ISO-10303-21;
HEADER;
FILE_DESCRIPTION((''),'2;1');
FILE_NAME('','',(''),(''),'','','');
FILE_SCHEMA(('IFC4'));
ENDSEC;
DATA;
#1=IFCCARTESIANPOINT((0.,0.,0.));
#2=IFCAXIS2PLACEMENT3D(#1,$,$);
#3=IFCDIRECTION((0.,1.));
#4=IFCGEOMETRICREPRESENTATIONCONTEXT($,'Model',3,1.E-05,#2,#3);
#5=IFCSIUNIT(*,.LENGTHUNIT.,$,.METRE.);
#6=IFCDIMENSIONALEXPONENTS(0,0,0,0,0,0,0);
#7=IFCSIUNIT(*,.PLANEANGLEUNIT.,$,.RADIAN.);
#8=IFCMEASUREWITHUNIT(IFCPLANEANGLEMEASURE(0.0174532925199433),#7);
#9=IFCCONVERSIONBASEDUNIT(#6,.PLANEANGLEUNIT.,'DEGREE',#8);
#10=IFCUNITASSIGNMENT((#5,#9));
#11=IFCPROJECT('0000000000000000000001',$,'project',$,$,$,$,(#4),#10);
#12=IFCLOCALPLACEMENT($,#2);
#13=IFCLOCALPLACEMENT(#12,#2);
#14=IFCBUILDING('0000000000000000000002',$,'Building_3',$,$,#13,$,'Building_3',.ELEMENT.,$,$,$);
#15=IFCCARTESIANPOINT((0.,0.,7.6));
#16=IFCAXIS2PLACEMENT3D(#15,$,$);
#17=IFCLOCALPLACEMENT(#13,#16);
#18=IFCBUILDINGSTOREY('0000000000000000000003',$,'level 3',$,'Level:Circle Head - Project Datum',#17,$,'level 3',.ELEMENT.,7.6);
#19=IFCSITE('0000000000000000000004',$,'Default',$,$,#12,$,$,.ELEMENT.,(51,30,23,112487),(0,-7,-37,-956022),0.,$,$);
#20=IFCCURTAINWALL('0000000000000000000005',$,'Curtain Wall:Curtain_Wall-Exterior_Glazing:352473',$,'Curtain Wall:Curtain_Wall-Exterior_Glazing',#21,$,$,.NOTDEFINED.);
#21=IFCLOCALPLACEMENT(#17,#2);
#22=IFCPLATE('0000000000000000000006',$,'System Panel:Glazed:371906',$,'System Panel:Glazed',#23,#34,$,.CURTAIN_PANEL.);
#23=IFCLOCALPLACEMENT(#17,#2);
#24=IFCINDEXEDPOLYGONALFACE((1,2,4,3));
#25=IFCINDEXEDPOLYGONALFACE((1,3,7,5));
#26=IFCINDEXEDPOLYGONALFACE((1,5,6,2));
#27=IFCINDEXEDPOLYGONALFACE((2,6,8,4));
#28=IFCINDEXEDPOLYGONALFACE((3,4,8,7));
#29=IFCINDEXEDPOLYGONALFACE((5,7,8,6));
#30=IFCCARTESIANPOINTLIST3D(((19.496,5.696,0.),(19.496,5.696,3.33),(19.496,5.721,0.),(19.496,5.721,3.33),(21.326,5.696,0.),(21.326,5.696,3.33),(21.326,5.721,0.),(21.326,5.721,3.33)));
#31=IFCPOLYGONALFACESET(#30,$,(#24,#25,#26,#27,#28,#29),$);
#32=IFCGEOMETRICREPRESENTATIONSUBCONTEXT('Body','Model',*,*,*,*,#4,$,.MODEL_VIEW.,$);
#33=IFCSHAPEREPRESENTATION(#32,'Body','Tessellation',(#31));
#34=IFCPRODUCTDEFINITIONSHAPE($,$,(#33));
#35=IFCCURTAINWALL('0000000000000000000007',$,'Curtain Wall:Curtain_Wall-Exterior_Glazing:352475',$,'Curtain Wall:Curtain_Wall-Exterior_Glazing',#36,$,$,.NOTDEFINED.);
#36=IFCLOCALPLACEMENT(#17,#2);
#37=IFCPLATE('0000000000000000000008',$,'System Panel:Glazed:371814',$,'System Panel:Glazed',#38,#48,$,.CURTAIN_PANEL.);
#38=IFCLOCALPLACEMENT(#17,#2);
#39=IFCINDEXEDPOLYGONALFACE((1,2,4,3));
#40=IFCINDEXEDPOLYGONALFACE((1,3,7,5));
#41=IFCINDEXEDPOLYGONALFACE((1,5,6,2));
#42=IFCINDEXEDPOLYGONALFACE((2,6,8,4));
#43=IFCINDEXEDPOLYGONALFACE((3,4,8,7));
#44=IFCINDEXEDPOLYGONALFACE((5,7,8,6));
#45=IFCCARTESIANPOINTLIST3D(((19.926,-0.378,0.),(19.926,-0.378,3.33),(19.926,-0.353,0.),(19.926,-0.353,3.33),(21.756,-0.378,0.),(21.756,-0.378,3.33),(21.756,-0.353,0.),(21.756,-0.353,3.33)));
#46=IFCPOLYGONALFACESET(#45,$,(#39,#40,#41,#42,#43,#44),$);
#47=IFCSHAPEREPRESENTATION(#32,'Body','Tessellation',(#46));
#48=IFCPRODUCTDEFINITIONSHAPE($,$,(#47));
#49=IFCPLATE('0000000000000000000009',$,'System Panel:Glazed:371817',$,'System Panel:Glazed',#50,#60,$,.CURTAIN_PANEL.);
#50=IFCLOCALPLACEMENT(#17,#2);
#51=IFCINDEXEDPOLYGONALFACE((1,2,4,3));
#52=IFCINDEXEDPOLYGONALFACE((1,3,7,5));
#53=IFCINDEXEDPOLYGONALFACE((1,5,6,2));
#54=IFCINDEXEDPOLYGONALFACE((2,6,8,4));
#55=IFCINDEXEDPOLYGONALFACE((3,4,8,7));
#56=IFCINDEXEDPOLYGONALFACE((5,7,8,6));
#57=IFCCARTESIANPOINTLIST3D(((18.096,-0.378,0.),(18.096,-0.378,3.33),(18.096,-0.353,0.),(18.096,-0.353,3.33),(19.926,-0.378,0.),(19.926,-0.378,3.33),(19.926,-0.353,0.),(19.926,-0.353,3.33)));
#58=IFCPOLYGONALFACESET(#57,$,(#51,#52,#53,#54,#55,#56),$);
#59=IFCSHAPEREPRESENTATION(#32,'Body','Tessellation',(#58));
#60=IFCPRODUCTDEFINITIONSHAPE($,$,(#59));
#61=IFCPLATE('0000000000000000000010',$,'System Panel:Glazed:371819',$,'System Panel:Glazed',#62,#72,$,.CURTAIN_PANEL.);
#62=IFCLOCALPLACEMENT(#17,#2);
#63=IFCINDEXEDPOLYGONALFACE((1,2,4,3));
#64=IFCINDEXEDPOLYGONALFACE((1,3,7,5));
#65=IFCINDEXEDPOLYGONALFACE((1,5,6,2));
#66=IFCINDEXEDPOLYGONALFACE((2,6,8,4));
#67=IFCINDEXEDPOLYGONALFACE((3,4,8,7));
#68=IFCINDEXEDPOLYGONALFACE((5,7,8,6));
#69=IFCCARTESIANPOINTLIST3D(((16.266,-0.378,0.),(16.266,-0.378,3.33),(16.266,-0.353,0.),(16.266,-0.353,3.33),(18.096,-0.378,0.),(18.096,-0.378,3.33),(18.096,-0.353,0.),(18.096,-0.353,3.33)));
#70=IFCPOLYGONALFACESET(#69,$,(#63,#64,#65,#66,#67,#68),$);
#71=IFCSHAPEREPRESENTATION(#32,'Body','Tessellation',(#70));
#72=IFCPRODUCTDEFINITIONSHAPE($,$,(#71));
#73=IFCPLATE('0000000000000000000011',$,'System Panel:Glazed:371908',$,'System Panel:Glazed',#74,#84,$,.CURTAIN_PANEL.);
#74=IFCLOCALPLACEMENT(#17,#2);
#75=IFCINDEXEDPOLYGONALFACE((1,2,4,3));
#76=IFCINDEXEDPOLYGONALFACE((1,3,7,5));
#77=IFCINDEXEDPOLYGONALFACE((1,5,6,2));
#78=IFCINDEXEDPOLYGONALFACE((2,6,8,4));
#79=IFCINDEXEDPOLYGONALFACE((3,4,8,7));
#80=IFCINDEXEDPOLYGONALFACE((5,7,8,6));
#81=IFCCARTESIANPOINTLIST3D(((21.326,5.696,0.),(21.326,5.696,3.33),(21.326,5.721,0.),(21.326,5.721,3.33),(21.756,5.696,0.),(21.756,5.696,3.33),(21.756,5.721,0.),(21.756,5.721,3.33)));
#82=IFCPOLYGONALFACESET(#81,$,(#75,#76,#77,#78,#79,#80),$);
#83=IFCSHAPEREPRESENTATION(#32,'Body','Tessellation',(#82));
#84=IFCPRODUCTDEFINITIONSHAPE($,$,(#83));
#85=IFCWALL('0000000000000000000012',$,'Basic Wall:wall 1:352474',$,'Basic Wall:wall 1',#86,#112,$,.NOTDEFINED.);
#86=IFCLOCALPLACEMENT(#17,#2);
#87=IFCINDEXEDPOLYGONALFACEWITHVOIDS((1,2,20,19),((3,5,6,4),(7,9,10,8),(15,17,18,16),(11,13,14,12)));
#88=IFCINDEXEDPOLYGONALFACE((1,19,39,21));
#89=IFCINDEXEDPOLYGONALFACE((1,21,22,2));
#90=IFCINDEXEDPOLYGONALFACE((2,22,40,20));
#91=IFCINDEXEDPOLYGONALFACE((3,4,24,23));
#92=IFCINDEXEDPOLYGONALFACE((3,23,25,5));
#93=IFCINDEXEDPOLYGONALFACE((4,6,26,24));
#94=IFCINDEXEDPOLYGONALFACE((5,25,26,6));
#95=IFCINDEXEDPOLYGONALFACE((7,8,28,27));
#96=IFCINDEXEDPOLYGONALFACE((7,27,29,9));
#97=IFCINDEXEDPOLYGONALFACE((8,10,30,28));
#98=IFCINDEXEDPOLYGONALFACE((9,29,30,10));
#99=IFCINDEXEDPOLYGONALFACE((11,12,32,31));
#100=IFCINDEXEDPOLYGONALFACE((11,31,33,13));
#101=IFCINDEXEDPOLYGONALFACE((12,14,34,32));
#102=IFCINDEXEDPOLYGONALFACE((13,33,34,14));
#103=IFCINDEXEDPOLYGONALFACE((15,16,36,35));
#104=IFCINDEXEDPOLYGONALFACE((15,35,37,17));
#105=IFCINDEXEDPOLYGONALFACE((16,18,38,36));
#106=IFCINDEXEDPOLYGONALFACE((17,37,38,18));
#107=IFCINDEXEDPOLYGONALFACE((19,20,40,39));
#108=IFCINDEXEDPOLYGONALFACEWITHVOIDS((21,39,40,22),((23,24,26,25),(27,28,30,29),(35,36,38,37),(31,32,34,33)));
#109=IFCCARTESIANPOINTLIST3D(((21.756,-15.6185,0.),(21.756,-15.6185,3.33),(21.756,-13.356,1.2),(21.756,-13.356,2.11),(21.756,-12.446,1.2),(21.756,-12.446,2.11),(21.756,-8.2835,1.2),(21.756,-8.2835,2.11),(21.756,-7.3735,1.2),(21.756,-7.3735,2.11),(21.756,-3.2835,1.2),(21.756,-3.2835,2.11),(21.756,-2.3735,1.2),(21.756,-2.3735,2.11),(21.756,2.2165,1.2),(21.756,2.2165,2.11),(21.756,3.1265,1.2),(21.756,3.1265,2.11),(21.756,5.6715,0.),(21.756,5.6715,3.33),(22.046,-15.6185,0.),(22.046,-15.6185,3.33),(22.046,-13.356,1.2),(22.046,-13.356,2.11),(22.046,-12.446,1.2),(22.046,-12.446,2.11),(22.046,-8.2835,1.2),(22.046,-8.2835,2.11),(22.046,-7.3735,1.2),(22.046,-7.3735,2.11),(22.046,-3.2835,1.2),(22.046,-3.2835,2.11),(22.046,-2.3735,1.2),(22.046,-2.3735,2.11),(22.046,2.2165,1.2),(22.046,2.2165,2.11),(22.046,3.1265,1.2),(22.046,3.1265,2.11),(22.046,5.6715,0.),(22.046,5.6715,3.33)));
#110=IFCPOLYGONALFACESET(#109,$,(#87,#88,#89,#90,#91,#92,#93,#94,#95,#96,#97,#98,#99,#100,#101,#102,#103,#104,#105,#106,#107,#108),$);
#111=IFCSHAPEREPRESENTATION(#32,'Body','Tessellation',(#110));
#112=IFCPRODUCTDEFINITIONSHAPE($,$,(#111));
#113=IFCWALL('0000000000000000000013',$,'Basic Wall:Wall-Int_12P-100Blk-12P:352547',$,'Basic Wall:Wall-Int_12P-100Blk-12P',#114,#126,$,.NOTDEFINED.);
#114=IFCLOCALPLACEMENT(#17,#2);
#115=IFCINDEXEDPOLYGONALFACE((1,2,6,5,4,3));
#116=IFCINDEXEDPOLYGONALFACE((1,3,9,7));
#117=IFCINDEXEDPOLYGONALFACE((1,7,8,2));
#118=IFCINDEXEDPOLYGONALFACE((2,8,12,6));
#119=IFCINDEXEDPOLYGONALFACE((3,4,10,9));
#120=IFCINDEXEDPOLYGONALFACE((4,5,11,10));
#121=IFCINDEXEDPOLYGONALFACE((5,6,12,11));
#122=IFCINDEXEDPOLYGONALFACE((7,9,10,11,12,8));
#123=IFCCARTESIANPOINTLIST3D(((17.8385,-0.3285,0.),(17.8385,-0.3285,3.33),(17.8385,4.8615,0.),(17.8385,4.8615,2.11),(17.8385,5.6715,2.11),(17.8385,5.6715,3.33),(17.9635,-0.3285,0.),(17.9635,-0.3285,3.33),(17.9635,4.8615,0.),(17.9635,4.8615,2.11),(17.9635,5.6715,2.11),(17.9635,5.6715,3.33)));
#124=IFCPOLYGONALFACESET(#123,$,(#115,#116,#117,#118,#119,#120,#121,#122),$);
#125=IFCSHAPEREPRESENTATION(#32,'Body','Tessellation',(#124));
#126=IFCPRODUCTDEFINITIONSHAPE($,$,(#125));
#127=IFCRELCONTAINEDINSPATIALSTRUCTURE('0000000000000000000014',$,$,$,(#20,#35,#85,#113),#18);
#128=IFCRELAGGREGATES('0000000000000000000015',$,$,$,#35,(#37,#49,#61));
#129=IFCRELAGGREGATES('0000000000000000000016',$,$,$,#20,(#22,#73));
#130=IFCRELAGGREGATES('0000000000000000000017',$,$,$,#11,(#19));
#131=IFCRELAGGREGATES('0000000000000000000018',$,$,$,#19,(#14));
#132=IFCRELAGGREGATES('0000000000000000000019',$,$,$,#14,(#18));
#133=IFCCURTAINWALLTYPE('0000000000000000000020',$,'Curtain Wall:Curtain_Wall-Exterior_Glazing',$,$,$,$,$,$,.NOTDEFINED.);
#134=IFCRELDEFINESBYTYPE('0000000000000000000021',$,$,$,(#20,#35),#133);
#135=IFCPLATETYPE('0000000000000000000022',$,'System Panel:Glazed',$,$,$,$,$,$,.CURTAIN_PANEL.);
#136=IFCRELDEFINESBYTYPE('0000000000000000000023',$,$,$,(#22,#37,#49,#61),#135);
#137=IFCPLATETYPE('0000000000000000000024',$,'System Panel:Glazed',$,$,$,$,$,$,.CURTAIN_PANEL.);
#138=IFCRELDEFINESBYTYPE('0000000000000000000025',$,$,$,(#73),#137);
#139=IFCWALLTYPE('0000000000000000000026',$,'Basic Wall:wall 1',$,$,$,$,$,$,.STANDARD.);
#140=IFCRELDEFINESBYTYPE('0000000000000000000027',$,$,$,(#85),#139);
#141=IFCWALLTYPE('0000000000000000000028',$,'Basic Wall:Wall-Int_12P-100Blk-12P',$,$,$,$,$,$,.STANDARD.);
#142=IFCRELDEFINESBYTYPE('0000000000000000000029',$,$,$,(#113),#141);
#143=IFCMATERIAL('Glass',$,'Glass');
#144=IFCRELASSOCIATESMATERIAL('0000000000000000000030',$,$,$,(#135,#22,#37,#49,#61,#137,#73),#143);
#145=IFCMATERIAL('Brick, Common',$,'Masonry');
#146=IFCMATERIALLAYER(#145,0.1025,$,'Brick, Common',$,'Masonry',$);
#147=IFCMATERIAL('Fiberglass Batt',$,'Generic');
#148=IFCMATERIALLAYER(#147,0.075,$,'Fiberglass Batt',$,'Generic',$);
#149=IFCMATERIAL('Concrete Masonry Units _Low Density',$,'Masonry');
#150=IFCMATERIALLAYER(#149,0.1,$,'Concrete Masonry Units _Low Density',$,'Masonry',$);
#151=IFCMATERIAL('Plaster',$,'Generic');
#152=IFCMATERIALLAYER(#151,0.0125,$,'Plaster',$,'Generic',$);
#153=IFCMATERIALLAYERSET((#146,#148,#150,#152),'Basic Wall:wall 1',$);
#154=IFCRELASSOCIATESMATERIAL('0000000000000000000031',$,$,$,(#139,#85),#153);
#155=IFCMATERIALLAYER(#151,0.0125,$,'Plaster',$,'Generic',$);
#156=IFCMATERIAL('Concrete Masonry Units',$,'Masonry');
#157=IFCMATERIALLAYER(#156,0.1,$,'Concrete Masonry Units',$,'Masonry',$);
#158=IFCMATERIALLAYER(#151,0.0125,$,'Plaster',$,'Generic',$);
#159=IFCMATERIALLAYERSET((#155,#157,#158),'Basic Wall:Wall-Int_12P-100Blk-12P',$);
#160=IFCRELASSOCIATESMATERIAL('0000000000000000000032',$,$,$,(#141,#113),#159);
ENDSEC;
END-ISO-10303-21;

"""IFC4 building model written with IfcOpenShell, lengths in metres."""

from ifc_helpers import new_model, entity, si_unit, converted_unit, direction, frame, frame_2d, origin, origin_2d_with_axis, place, context, subcontext, project, spatial, polyline, rectangle, extrude, clip, bounded_halfspace, source, transform, mapped, material, layer, layer_set, layer_usage, type_object, type_shapes, element, aggregate, save


model = new_model("IFC4")

# Units and contexts
model_context = context("Model", 3, precision=1e-05, world=origin(), true_north=direction((0.0, 1.0)))
body_context = subcontext(model_context, "Body", "Model", "MODEL_VIEW")
ifc_project = project(units=[si_unit("LENGTHUNIT", "METRE"), converted_unit("PLANEANGLEUNIT", "DEGREE", entity("IfcPlaneAngleMeasure", 0.0174532925199433), si_unit("PLANEANGLEUNIT", "RADIAN"), dimensions=[0, 0, 0, 0, 0, 0, 0])], contexts=[model_context])

# Site, building, storey
site_placement = place(None, origin())
site = spatial("IfcSite", under=ifc_project, at=site_placement, Name="Default", CompositionType="ELEMENT", RefLatitude=(51, 30, 23, 112487), RefLongitude=(0, -7, -37, -956022), RefElevation=0.0)
building_placement = place(site_placement, origin())
building = spatial("IfcBuilding", under=site, at=building_placement, Name="Building_3", LongName="Building_3", CompositionType="ELEMENT")
storey_placement = place(building_placement, frame((0.0, 0.0, 7.6)))
storey = spatial("IfcBuildingStorey", under=building, at=storey_placement, Name="level 3", ObjectType="Level:Circle Head - Project Datum", LongName="level 3", CompositionType="ELEMENT", Elevation=7.6)

# Curtain wall, plate
curtain_wall_type = type_object("IfcCurtainWallType", Name="Curtain Wall:Curtain_Wall-Exterior_Glazing", PredefinedType="NOTDEFINED")
curtain_wall_1_placement = place(storey_placement, frame((0.0, 0.0, -7.6)))
curtain_wall_1 = element("IfcCurtainWall", 1, at=curtain_wall_1_placement, inside=storey, type_object=curtain_wall_type, Name="Curtain Wall:Curtain_Wall-Exterior_Glazing:352473", ObjectType="Curtain Wall:Curtain_Wall-Exterior_Glazing", PredefinedType="NOTDEFINED")
ifc_material_1 = material(Name="Glass", Category="Glass")
plate_type_1 = type_object("IfcPlateType", Name="System Panel:Glazed", PredefinedType="CURTAIN_PANEL", material=ifc_material_1)
shared_shape_1 = source(origin(), body_context, "Body", "SweptSolid", [
    extrude(rectangle(XDim=0.025, YDim=1.83, at=origin_2d_with_axis()), frame((0.915, 0.0125, 0.0), z_axis=(0.0, 0.0, 1.0), x_axis=(0.0, 1.0, 0.0)), (0.0, 0.0, 1.0), 3.33),
])
type_shapes(plate_type_1, [shared_shape_1])
plate_1_placement = place(curtain_wall_1_placement, frame((19.496, 5.696, 7.6)))
plate_1 = element("IfcPlate", 2, at=plate_1_placement, type_object=plate_type_1, material=ifc_material_1, Name="System Panel:Glazed:371906", ObjectType="System Panel:Glazed", PredefinedType="CURTAIN_PANEL", context=body_context, shape_type="MappedRepresentation", body=[
    mapped(shared_shape_1, transform((0.0, 0.0, 0.0), scale=1.0)),
])

# Curtain wall, plates
curtain_wall_2_placement = place(storey_placement, frame((0.0, 0.0, -7.6)))
curtain_wall_2 = element("IfcCurtainWall", 3, at=curtain_wall_2_placement, inside=storey, type_object=curtain_wall_type, Name="Curtain Wall:Curtain_Wall-Exterior_Glazing:352475", ObjectType="Curtain Wall:Curtain_Wall-Exterior_Glazing", PredefinedType="NOTDEFINED")
plate_2_placement = place(curtain_wall_2_placement, frame((21.756, -0.353, 7.6), z_axis=(0.0, 0.0, 1.0), x_axis=(-1.0, 0.0, 0.0)))
plate_2 = element("IfcPlate", 4, at=plate_2_placement, type_object=plate_type_1, material=ifc_material_1, Name="System Panel:Glazed:371814", ObjectType="System Panel:Glazed", PredefinedType="CURTAIN_PANEL", context=body_context, shape_type="MappedRepresentation", body=[
    mapped(shared_shape_1, transform((0.0, 0.0, 0.0), scale=1.0)),
])
plate_3_placement = place(curtain_wall_2_placement, frame((19.926, -0.353, 7.6), z_axis=(0.0, 0.0, 1.0), x_axis=(-1.0, 0.0, 0.0)))
plate_3 = element("IfcPlate", 5, at=plate_3_placement, type_object=plate_type_1, material=ifc_material_1, Name="System Panel:Glazed:371817", ObjectType="System Panel:Glazed", PredefinedType="CURTAIN_PANEL", context=body_context, shape_type="MappedRepresentation", body=[
    mapped(shared_shape_1, transform((0.0, 0.0, 0.0), scale=1.0)),
])
plate_4_placement = place(curtain_wall_2_placement, frame((18.096, -0.353, 7.6), z_axis=(0.0, 0.0, 1.0), x_axis=(-1.0, 0.0, 0.0)))
plate_4 = element("IfcPlate", 6, at=plate_4_placement, type_object=plate_type_1, material=ifc_material_1, Name="System Panel:Glazed:371819", ObjectType="System Panel:Glazed", PredefinedType="CURTAIN_PANEL", context=body_context, shape_type="MappedRepresentation", body=[
    mapped(shared_shape_1, transform((0.0, 0.0, 0.0), scale=1.0)),
])
aggregate(curtain_wall_2, [plate_2, plate_3, plate_4])

# Plate
plate_type_2 = type_object("IfcPlateType", Name="System Panel:Glazed", PredefinedType="CURTAIN_PANEL", material=ifc_material_1)
shared_shape_2 = source(origin(), body_context, "Body", "SweptSolid", [
    extrude(rectangle(XDim=0.025, YDim=0.43, at=origin_2d_with_axis()), frame((0.215, 0.0125, 0.0), z_axis=(0.0, 0.0, 1.0), x_axis=(0.0, 1.0, 0.0)), (0.0, 0.0, 1.0), 3.33),
])
type_shapes(plate_type_2, [shared_shape_2])
plate_5_placement = place(curtain_wall_1_placement, frame((21.326, 5.696, 7.6)))
plate_5 = element("IfcPlate", 7, at=plate_5_placement, type_object=plate_type_2, material=ifc_material_1, Name="System Panel:Glazed:371908", ObjectType="System Panel:Glazed", PredefinedType="CURTAIN_PANEL", context=body_context, shape_type="MappedRepresentation", body=[
    mapped(shared_shape_2, transform((0.0, 0.0, 0.0), scale=1.0)),
])
aggregate(curtain_wall_1, [plate_1, plate_5])

# Wall, openings
ifc_material_2 = material(Name="Brick, Common", Category="Masonry")
ifc_layer_1 = layer(ifc_material_2, 0.1025, Name="Brick, Common", Category="Masonry")
ifc_material_3 = material(Name="Fiberglass Batt", Category="Generic")
ifc_layer_2 = layer(ifc_material_3, 0.075, Name="Fiberglass Batt", Category="Generic")
ifc_material_4 = material(Name="Concrete Masonry Units _Low Density", Category="Masonry")
ifc_layer_3 = layer(ifc_material_4, 0.1, Name="Concrete Masonry Units _Low Density", Category="Masonry")
ifc_material_5 = material(Name="Plaster", Category="Generic")
ifc_layer_4 = layer(ifc_material_5, 0.0125, Name="Plaster", Category="Generic")
ifc_layer_set_1 = layer_set([ifc_layer_1, ifc_layer_2, ifc_layer_3, ifc_layer_4], Name="Basic Wall:wall 1")
ifc_layer_usage_1 = layer_usage(ifc_layer_set_1, "AXIS2", "NEGATIVE", 0.145)
wall_type_1 = type_object("IfcWallType", Name="Basic Wall:wall 1", PredefinedType="STANDARD", material=ifc_layer_set_1)
wall_1_placement = place(storey_placement, frame((21.901, 5.6715, 0.0), z_axis=(0.0, 0.0, 1.0), x_axis=(0.0, -1.0, 0.0)))
wall_1 = element("IfcWall", 8, at=wall_1_placement, inside=storey, type_object=wall_type_1, material=ifc_layer_usage_1, Name="Basic Wall:wall 1:352474", ObjectType="Basic Wall:wall 1", PredefinedType="NOTDEFINED", context=body_context, shape_type="Clipping", body=[
    clip(extrude(rectangle(XDim=21.29, YDim=0.29, at=frame_2d((10.645, 0.0), x_axis=(-1.0, 0.0))), origin(), (0.0, 0.0, 1.0), 3.33), bounded_halfspace(frame((0.0, -0.145, 3.33), z_axis=(0.0, 0.0, -1.0), x_axis=(-1.0, 0.0, 0.0)), True, frame((0.0, -0.145, 3.33)), polyline([(0.0, 0.0), (10.9375, 0.0), (11.0625, 0.0), (15.9375, 0.0), (16.0625, 0.0), (21.0, 0.0), (21.29, 0.0), (21.29, 0.29), (0.0, 0.29), (0.0, 0.0)]))),
])
opening_1_placement = place(wall_1_placement, frame((5.6715, -21.901, 0.0)))
element("IfcOpeningElement", 9, at=opening_1_placement, cuts=wall_1, PredefinedType="OPENING", context=body_context, shape_type="SweptSolid", body=[
    extrude(rectangle(XDim=2.11, YDim=0.125, at=frame_2d((0.0, 0.0), x_axis=(0.0, 1.0))), frame((5.3285, 20.946, 1.055), z_axis=(0.0, 1.0, 0.0), x_axis=(1.0, 0.0, 0.0)), (0.0, 0.0, 1.0), 0.81),
])
opening_2_placement = place(wall_1_placement, frame((5.6715, -21.901, 0.0)))
element("IfcOpeningElement", 10, at=opening_2_placement, cuts=wall_1, PredefinedType="OPENING", context=body_context, shape_type="SweptSolid", body=[
    extrude(rectangle(XDim=2.11, YDim=0.125, at=frame_2d((0.0, 0.0), x_axis=(0.0, 1.0))), frame((10.3285, 20.946, 1.055), z_axis=(0.0, 1.0, 0.0), x_axis=(1.0, 0.0, 0.0)), (0.0, 0.0, 1.0), 0.81),
])
opening_3_placement = place(wall_1_placement, frame((2.545, -0.145, 1.2)))
element("IfcOpeningElement", 11, at=opening_3_placement, cuts=wall_1, PredefinedType="OPENING", context=body_context, shape_type="SweptSolid", body=[
    extrude(rectangle(XDim=0.91, YDim=0.91, at=frame_2d((0.455, 0.455), x_axis=(-1.0, 0.0))), frame((0.0, 0.0, 0.0), z_axis=(0.0, 1.0, 0.0), x_axis=(0.0, 0.0, 1.0)), (0.0, 0.0, 1.0), 0.29),
])
opening_4_placement = place(wall_1_placement, frame((8.045, -0.145, 1.2)))
element("IfcOpeningElement", 12, at=opening_4_placement, cuts=wall_1, PredefinedType="OPENING", context=body_context, shape_type="SweptSolid", body=[
    extrude(rectangle(XDim=0.91, YDim=0.91, at=frame_2d((0.455, 0.455), x_axis=(-1.0, 0.0))), frame((0.0, 0.0, 0.0), z_axis=(0.0, 1.0, 0.0), x_axis=(0.0, 0.0, 1.0)), (0.0, 0.0, 1.0), 0.29),
])
opening_5_placement = place(wall_1_placement, frame((18.1175, -0.145, 1.2)))
element("IfcOpeningElement", 13, at=opening_5_placement, cuts=wall_1, PredefinedType="OPENING", context=body_context, shape_type="SweptSolid", body=[
    extrude(rectangle(XDim=0.91, YDim=0.91, at=frame_2d((0.455, 0.455), x_axis=(-1.0, 0.0))), frame((0.0, 0.0, 0.0), z_axis=(0.0, 1.0, 0.0), x_axis=(0.0, 0.0, 1.0)), (0.0, 0.0, 1.0), 0.29),
])
opening_6_placement = place(wall_1_placement, frame((13.045, -0.145, 1.2)))
element("IfcOpeningElement", 14, at=opening_6_placement, cuts=wall_1, PredefinedType="OPENING", context=body_context, shape_type="SweptSolid", body=[
    extrude(rectangle(XDim=0.91, YDim=0.91, at=frame_2d((0.455, 0.455), x_axis=(-1.0, 0.0))), frame((0.0, 0.0, 0.0), z_axis=(0.0, 1.0, 0.0), x_axis=(0.0, 0.0, 1.0)), (0.0, 0.0, 1.0), 0.29),
])

# Wall, opening
ifc_layer_5 = layer(ifc_material_5, 0.0125, Name="Plaster", Category="Generic")
ifc_material_6 = material(Name="Concrete Masonry Units", Category="Masonry")
ifc_layer_6 = layer(ifc_material_6, 0.1, Name="Concrete Masonry Units", Category="Masonry")
ifc_layer_7 = layer(ifc_material_5, 0.0125, Name="Plaster", Category="Generic")
ifc_layer_set_2 = layer_set([ifc_layer_5, ifc_layer_6, ifc_layer_7], Name="Basic Wall:Wall-Int_12P-100Blk-12P")
ifc_layer_usage_2 = layer_usage(ifc_layer_set_2, "AXIS2", "NEGATIVE", 0.0625)
wall_type_2 = type_object("IfcWallType", Name="Basic Wall:Wall-Int_12P-100Blk-12P", PredefinedType="STANDARD", material=ifc_layer_set_2)
wall_2_placement = place(storey_placement, frame((17.901, 5.6715, 0.0), z_axis=(0.0, 0.0, 1.0), x_axis=(0.0, -1.0, 0.0)))
wall_2 = element("IfcWall", 15, at=wall_2_placement, inside=storey, type_object=wall_type_2, material=ifc_layer_usage_2, Name="Basic Wall:Wall-Int_12P-100Blk-12P:352547", ObjectType="Basic Wall:Wall-Int_12P-100Blk-12P", PredefinedType="NOTDEFINED", context=body_context, shape_type="Clipping", body=[
    clip(extrude(rectangle(XDim=6.0, YDim=0.125, at=frame_2d((3.0, 0.0), x_axis=(-1.0, 0.0))), origin(), (0.0, 0.0, 1.0), 3.33), bounded_halfspace(frame((0.0, -0.0625, 3.33), z_axis=(0.0, 0.0, -1.0), x_axis=(-1.0, 0.0, 0.0)), True, frame((0.0, -0.0625, 3.33)), polyline([(0.0, 0.0), (6.0, 0.0), (6.0, 0.125), (0.0, 0.125), (0.0, 0.0)]))),
])
opening_7_placement = place(wall_2_placement, frame((0.0, -0.0625, 0.0)))
element("IfcOpeningElement", 16, at=opening_7_placement, cuts=wall_2, PredefinedType="OPENING", context=body_context, shape_type="SweptSolid", body=[
    extrude(rectangle(XDim=2.11, YDim=0.81, at=frame_2d((1.055, 0.405), x_axis=(1.0, 0.0))), frame((0.0, 0.0, 0.0), z_axis=(0.0, 1.0, 0.0), x_axis=(0.0, 0.0, 1.0)), (0.0, 0.0, 1.0), 0.125),
])

save(model, "model.ifc")
